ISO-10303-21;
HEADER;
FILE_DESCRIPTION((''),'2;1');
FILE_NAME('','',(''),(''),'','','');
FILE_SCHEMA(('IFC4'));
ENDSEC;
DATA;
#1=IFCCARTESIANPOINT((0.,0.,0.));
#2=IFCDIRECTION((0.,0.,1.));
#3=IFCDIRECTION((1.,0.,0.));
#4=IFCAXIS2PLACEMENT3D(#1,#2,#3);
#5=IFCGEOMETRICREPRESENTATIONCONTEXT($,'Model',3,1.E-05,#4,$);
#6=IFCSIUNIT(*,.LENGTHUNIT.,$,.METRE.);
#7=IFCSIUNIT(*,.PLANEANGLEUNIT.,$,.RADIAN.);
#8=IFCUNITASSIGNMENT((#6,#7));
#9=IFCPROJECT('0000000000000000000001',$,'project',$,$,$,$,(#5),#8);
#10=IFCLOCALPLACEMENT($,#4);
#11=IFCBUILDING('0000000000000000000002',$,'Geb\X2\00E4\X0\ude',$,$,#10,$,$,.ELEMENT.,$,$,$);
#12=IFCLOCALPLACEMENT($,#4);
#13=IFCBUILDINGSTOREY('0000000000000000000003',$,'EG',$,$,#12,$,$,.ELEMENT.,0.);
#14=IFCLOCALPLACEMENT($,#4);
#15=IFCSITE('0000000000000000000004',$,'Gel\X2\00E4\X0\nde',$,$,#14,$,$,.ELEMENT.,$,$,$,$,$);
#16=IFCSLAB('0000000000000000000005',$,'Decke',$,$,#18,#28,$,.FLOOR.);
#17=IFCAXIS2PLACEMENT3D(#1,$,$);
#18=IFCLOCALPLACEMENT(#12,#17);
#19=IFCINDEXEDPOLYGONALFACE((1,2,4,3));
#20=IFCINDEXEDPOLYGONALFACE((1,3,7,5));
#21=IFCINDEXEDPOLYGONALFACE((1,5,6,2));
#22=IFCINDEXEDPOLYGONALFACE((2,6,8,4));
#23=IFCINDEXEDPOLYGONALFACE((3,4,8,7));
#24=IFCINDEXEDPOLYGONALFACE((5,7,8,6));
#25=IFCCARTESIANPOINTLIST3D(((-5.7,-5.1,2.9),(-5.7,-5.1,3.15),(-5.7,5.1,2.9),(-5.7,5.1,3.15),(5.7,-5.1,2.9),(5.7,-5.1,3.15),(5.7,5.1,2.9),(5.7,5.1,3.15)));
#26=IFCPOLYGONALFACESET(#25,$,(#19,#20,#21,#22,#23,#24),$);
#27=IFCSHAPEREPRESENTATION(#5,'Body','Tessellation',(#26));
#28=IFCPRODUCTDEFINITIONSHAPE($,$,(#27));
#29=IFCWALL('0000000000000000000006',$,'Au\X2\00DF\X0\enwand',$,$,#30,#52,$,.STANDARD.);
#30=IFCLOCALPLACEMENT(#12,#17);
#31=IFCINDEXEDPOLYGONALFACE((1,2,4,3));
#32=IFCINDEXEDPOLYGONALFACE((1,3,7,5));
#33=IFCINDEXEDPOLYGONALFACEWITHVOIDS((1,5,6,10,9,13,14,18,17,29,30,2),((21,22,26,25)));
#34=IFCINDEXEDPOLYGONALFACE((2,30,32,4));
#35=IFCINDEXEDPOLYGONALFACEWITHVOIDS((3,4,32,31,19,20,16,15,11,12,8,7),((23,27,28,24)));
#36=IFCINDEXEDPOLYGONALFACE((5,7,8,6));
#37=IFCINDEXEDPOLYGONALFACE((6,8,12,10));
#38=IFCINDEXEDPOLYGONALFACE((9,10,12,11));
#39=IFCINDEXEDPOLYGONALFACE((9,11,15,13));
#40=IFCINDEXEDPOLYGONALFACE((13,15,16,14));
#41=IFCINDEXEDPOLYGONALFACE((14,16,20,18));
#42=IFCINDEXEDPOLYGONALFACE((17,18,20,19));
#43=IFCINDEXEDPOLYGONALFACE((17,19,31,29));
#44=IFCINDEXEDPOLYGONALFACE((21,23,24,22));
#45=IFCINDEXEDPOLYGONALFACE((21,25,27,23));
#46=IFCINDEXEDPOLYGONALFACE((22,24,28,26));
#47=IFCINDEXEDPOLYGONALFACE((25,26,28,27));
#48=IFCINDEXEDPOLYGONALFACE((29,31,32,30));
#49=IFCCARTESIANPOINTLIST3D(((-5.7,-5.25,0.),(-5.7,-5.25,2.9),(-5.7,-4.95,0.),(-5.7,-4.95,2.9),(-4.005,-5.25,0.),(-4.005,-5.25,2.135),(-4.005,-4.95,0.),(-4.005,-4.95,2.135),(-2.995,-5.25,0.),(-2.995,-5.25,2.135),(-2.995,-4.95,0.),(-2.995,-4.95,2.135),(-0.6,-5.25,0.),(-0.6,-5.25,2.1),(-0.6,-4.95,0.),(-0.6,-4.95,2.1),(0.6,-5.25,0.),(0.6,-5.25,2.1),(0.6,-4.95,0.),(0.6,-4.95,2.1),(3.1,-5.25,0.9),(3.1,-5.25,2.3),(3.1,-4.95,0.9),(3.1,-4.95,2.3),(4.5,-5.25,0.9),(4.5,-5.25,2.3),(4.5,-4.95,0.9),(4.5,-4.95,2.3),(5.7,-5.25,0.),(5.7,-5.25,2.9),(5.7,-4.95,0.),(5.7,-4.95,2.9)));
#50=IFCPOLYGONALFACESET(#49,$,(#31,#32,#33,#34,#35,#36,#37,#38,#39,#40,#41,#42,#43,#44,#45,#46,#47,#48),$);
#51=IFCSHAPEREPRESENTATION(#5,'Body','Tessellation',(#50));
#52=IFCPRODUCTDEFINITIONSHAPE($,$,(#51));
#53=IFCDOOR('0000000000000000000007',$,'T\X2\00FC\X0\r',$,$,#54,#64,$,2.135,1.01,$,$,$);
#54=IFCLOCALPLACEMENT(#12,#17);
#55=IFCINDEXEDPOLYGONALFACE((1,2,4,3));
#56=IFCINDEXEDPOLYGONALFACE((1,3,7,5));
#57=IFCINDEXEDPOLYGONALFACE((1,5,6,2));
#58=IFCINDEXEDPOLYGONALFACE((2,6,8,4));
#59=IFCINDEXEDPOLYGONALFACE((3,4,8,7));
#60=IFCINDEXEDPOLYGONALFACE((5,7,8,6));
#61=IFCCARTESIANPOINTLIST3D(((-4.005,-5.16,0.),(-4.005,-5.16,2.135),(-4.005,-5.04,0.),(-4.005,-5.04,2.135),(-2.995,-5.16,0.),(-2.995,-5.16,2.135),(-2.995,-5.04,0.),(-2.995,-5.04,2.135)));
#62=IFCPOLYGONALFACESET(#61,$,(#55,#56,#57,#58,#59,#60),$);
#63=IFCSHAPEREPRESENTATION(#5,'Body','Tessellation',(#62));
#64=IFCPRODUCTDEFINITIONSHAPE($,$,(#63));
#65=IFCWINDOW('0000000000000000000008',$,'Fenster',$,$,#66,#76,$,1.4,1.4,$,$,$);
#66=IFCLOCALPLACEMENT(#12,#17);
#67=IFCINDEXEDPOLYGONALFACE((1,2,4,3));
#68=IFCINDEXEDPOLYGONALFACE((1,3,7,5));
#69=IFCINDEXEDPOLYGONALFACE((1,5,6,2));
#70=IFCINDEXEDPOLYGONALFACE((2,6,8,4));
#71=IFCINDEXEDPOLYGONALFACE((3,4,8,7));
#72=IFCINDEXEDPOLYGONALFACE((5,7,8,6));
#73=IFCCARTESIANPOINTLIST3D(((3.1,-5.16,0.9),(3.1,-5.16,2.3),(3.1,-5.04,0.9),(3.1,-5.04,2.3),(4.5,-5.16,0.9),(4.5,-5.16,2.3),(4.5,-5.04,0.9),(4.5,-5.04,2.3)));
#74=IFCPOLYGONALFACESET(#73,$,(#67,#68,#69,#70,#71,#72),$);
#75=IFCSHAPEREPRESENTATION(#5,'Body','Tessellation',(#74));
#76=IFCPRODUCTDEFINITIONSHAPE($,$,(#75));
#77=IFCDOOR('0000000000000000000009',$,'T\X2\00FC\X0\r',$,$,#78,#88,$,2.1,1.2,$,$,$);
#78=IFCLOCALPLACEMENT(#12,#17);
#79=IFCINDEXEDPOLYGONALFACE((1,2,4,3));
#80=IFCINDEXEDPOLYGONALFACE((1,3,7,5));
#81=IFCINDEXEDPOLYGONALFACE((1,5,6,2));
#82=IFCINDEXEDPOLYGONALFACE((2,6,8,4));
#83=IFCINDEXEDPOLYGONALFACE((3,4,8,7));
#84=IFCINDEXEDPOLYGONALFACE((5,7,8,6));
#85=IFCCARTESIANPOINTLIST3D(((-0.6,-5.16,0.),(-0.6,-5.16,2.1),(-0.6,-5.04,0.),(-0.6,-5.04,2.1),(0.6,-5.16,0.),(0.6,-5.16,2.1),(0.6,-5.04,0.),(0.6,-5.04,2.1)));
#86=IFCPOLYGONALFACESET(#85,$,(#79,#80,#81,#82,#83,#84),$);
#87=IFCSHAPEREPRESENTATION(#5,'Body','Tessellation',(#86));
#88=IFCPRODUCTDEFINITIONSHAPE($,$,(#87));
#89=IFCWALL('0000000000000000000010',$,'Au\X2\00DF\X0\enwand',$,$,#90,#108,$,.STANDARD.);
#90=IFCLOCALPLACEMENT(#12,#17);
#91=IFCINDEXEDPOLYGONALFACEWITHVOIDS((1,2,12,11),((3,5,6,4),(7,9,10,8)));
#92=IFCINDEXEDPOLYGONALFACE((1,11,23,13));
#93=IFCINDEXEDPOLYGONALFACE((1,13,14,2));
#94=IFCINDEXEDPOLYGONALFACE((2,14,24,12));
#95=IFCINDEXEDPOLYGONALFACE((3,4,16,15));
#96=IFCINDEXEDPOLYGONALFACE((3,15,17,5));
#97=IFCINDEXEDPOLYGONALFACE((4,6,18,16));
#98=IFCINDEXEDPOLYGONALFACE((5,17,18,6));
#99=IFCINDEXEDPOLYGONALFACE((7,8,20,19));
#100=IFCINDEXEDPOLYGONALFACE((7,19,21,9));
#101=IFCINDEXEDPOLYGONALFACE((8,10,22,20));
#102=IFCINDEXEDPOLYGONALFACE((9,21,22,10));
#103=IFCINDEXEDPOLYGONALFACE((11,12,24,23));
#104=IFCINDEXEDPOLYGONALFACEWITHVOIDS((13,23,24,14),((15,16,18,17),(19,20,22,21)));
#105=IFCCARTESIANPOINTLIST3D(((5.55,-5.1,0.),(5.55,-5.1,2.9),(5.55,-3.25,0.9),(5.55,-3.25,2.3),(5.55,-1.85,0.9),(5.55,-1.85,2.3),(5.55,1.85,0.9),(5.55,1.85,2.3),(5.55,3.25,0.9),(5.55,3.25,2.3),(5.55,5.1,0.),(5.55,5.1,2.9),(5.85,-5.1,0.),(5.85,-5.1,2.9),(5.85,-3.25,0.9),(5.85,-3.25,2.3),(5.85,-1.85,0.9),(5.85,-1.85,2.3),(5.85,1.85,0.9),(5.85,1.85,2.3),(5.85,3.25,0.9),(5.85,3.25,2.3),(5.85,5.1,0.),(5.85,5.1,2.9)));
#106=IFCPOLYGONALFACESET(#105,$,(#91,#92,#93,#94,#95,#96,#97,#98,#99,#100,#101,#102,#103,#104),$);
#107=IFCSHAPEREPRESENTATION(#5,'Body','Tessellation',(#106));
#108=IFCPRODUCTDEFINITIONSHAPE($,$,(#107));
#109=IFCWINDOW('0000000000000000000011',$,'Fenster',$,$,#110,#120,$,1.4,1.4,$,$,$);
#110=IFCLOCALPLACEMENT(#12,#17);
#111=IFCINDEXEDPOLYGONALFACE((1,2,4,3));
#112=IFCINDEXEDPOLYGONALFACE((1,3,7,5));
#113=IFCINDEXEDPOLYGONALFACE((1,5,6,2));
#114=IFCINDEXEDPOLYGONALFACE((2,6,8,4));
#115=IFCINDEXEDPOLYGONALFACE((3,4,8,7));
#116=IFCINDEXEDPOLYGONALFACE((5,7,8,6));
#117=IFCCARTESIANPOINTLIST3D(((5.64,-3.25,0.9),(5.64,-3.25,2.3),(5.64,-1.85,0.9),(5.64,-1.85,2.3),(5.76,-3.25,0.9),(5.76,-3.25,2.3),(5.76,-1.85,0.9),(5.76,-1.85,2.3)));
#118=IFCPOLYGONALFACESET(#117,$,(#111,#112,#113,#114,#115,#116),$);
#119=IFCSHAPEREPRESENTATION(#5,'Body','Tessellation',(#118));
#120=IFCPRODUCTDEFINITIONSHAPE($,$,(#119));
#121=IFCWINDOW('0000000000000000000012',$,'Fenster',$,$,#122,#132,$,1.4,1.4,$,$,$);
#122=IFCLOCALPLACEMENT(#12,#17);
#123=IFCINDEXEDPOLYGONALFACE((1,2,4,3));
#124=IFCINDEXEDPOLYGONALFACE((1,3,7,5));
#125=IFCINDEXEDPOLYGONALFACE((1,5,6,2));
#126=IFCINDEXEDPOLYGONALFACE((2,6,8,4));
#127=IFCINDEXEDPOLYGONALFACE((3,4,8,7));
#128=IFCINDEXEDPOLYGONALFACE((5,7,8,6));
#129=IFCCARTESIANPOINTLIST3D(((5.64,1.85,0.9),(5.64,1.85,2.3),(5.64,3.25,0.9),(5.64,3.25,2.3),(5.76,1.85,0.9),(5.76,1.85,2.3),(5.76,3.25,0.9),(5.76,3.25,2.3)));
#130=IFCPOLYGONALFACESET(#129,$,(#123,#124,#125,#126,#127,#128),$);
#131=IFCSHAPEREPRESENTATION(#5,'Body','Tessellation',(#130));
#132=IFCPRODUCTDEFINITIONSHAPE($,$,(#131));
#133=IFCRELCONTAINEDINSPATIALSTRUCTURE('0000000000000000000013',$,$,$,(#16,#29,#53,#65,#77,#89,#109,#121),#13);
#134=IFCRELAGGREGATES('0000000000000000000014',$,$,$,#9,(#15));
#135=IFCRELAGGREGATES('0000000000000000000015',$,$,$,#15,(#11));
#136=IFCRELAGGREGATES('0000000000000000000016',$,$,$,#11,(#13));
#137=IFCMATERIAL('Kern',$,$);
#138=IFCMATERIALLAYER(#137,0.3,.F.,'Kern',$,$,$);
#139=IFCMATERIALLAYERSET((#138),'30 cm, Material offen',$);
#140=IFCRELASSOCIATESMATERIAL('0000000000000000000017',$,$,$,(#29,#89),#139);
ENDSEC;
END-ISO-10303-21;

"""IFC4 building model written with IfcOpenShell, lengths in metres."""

from ifc_helpers import new_model, si_unit, frame, origin_with_axes, origin_2d, place, context, project, spatial, polyline, rectangle, outline, extrude, material, layer, layer_set, element, fill, save


model = new_model("IFC4")

# Units and contexts
model_context = context("Model", 3, precision=1e-05, world=origin_with_axes())
ifc_project = project(units=[si_unit("LENGTHUNIT", "METRE"), si_unit("PLANEANGLEUNIT", "RADIAN")], contexts=[model_context])

# Site, building, storey
site_placement = place(None, origin_with_axes())
site = spatial("IfcSite", under=ifc_project, at=site_placement, Name="Gelände", CompositionType="ELEMENT")
building_placement = place(None, origin_with_axes())
building = spatial("IfcBuilding", under=site, at=building_placement, Name="Gebäude", CompositionType="ELEMENT")
storey_placement = place(None, origin_with_axes())
storey = spatial("IfcBuildingStorey", under=building, at=storey_placement, Name="EG", CompositionType="ELEMENT", Elevation=0.0)

# Slab
slab_placement = place(None, frame((0.0, 0.0, 2.9), z_axis=(0.0, 0.0, 1.0), x_axis=(1.0, 0.0, 0.0)))
element("IfcSlab", 1, at=slab_placement, inside=storey, Name="Decke", PredefinedType="FLOOR", context=model_context, shape_type="SweptSolid", body=[
    extrude(outline(polyline([(-5.7, -5.1), (5.7, -5.1), (5.7, 5.1), (-5.7, 5.1), (-5.7, -5.1)])), origin_with_axes(), (0.0, 0.0, 1.0), 0.25),
])

# Wall, openings, doors, window
ifc_material = material(Name="Kern")
ifc_layer_1 = layer(ifc_material, 0.3, ventilated=False, Name="Kern")
ifc_layer_set_1 = layer_set([ifc_layer_1], Name="30 cm, Material offen")
wall_1_placement = place(None, frame((0.0, -5.1, 0.0), z_axis=(0.0, 0.0, 1.0), x_axis=(1.0, 0.0, 0.0)))
wall_1 = element("IfcWall", 2, at=wall_1_placement, inside=storey, material=ifc_layer_set_1, Name="Außenwand", PredefinedType="STANDARD", context=model_context, shape_type="SweptSolid", body=[
    extrude(rectangle(XDim=11.4, YDim=0.3, at=origin_2d()), origin_with_axes(), (0.0, 0.0, 1.0), 2.9),
])
opening_1_placement = place(wall_1_placement, frame((-3.5, 0.0, 0.0), z_axis=(0.0, 0.0, 1.0), x_axis=(1.0, 0.0, 0.0)))
opening_1 = element("IfcOpeningElement", 3, at=opening_1_placement, cuts=wall_1, PredefinedType="OPENING", context=model_context, shape_type="SweptSolid", body=[
    extrude(rectangle(XDim=1.01, YDim=0.34, at=origin_2d()), origin_with_axes(), (0.0, 0.0, 1.0), 2.135),
])
opening_2_placement = place(wall_1_placement, frame((3.8, 0.0, 0.9), z_axis=(0.0, 0.0, 1.0), x_axis=(1.0, 0.0, 0.0)))
opening_2 = element("IfcOpeningElement", 4, at=opening_2_placement, cuts=wall_1, PredefinedType="OPENING", context=model_context, shape_type="SweptSolid", body=[
    extrude(rectangle(XDim=1.4, YDim=0.34, at=origin_2d()), origin_with_axes(), (0.0, 0.0, 1.0), 1.4),
])
opening_3_placement = place(wall_1_placement, origin_with_axes())
opening_3 = element("IfcOpeningElement", 5, at=opening_3_placement, cuts=wall_1, PredefinedType="OPENING", context=model_context, shape_type="SweptSolid", body=[
    extrude(rectangle(XDim=1.2, YDim=0.34, at=origin_2d()), origin_with_axes(), (0.0, 0.0, 1.0), 2.1),
])
door_1_placement = place(opening_1_placement, origin_with_axes())
door_1 = element("IfcDoor", 6, at=door_1_placement, inside=storey, Name="Tür", OverallHeight=2.135, OverallWidth=1.01, context=model_context, shape_type="SweptSolid", body=[
    extrude(rectangle(XDim=1.01, YDim=0.12, at=origin_2d()), origin_with_axes(), (0.0, 0.0, 1.0), 2.135),
])
fill(opening_1, door_1)
window_1_placement = place(opening_2_placement, origin_with_axes())
window_1 = element("IfcWindow", 7, at=window_1_placement, inside=storey, Name="Fenster", OverallHeight=1.4, OverallWidth=1.4, context=model_context, shape_type="SweptSolid", body=[
    extrude(rectangle(XDim=1.4, YDim=0.12, at=origin_2d()), origin_with_axes(), (0.0, 0.0, 1.0), 1.4),
])
fill(opening_2, window_1)
door_2_placement = place(opening_3_placement, origin_with_axes())
door_2 = element("IfcDoor", 8, at=door_2_placement, inside=storey, Name="Tür", OverallHeight=2.1, OverallWidth=1.2, context=model_context, shape_type="SweptSolid", body=[
    extrude(rectangle(XDim=1.2, YDim=0.12, at=origin_2d()), origin_with_axes(), (0.0, 0.0, 1.0), 2.1),
])
fill(opening_3, door_2)

# Wall, openings, windows
wall_2_placement = place(None, frame((5.7, 0.0, 0.0), z_axis=(0.0, 0.0, 1.0), x_axis=(0.0, 1.0, 0.0)))
wall_2 = element("IfcWall", 9, at=wall_2_placement, inside=storey, material=ifc_layer_set_1, Name="Außenwand", PredefinedType="STANDARD", context=model_context, shape_type="SweptSolid", body=[
    extrude(rectangle(XDim=10.2, YDim=0.3, at=origin_2d()), origin_with_axes(), (0.0, 0.0, 1.0), 2.9),
])
opening_4_placement = place(wall_2_placement, frame((-2.55, 0.0, 0.9), z_axis=(0.0, 0.0, 1.0), x_axis=(1.0, 0.0, 0.0)))
opening_4 = element("IfcOpeningElement", 10, at=opening_4_placement, cuts=wall_2, PredefinedType="OPENING", context=model_context, shape_type="SweptSolid", body=[
    extrude(rectangle(XDim=1.4, YDim=0.34, at=origin_2d()), origin_with_axes(), (0.0, 0.0, 1.0), 1.4),
])
opening_5_placement = place(wall_2_placement, frame((2.55, 0.0, 0.9), z_axis=(0.0, 0.0, 1.0), x_axis=(1.0, 0.0, 0.0)))
opening_5 = element("IfcOpeningElement", 11, at=opening_5_placement, cuts=wall_2, PredefinedType="OPENING", context=model_context, shape_type="SweptSolid", body=[
    extrude(rectangle(XDim=1.4, YDim=0.34, at=origin_2d()), origin_with_axes(), (0.0, 0.0, 1.0), 1.4),
])
window_2_placement = place(opening_4_placement, origin_with_axes())
window_2 = element("IfcWindow", 12, at=window_2_placement, inside=storey, Name="Fenster", OverallHeight=1.4, OverallWidth=1.4, context=model_context, shape_type="SweptSolid", body=[
    extrude(rectangle(XDim=1.4, YDim=0.12, at=origin_2d()), origin_with_axes(), (0.0, 0.0, 1.0), 1.4),
])
fill(opening_4, window_2)
window_3_placement = place(opening_5_placement, origin_with_axes())
window_3 = element("IfcWindow", 13, at=window_3_placement, inside=storey, Name="Fenster", OverallHeight=1.4, OverallWidth=1.4, context=model_context, shape_type="SweptSolid", body=[
    extrude(rectangle(XDim=1.4, YDim=0.12, at=origin_2d()), origin_with_axes(), (0.0, 0.0, 1.0), 1.4),
])
fill(opening_5, window_3)

save(model, "model.ifc")
